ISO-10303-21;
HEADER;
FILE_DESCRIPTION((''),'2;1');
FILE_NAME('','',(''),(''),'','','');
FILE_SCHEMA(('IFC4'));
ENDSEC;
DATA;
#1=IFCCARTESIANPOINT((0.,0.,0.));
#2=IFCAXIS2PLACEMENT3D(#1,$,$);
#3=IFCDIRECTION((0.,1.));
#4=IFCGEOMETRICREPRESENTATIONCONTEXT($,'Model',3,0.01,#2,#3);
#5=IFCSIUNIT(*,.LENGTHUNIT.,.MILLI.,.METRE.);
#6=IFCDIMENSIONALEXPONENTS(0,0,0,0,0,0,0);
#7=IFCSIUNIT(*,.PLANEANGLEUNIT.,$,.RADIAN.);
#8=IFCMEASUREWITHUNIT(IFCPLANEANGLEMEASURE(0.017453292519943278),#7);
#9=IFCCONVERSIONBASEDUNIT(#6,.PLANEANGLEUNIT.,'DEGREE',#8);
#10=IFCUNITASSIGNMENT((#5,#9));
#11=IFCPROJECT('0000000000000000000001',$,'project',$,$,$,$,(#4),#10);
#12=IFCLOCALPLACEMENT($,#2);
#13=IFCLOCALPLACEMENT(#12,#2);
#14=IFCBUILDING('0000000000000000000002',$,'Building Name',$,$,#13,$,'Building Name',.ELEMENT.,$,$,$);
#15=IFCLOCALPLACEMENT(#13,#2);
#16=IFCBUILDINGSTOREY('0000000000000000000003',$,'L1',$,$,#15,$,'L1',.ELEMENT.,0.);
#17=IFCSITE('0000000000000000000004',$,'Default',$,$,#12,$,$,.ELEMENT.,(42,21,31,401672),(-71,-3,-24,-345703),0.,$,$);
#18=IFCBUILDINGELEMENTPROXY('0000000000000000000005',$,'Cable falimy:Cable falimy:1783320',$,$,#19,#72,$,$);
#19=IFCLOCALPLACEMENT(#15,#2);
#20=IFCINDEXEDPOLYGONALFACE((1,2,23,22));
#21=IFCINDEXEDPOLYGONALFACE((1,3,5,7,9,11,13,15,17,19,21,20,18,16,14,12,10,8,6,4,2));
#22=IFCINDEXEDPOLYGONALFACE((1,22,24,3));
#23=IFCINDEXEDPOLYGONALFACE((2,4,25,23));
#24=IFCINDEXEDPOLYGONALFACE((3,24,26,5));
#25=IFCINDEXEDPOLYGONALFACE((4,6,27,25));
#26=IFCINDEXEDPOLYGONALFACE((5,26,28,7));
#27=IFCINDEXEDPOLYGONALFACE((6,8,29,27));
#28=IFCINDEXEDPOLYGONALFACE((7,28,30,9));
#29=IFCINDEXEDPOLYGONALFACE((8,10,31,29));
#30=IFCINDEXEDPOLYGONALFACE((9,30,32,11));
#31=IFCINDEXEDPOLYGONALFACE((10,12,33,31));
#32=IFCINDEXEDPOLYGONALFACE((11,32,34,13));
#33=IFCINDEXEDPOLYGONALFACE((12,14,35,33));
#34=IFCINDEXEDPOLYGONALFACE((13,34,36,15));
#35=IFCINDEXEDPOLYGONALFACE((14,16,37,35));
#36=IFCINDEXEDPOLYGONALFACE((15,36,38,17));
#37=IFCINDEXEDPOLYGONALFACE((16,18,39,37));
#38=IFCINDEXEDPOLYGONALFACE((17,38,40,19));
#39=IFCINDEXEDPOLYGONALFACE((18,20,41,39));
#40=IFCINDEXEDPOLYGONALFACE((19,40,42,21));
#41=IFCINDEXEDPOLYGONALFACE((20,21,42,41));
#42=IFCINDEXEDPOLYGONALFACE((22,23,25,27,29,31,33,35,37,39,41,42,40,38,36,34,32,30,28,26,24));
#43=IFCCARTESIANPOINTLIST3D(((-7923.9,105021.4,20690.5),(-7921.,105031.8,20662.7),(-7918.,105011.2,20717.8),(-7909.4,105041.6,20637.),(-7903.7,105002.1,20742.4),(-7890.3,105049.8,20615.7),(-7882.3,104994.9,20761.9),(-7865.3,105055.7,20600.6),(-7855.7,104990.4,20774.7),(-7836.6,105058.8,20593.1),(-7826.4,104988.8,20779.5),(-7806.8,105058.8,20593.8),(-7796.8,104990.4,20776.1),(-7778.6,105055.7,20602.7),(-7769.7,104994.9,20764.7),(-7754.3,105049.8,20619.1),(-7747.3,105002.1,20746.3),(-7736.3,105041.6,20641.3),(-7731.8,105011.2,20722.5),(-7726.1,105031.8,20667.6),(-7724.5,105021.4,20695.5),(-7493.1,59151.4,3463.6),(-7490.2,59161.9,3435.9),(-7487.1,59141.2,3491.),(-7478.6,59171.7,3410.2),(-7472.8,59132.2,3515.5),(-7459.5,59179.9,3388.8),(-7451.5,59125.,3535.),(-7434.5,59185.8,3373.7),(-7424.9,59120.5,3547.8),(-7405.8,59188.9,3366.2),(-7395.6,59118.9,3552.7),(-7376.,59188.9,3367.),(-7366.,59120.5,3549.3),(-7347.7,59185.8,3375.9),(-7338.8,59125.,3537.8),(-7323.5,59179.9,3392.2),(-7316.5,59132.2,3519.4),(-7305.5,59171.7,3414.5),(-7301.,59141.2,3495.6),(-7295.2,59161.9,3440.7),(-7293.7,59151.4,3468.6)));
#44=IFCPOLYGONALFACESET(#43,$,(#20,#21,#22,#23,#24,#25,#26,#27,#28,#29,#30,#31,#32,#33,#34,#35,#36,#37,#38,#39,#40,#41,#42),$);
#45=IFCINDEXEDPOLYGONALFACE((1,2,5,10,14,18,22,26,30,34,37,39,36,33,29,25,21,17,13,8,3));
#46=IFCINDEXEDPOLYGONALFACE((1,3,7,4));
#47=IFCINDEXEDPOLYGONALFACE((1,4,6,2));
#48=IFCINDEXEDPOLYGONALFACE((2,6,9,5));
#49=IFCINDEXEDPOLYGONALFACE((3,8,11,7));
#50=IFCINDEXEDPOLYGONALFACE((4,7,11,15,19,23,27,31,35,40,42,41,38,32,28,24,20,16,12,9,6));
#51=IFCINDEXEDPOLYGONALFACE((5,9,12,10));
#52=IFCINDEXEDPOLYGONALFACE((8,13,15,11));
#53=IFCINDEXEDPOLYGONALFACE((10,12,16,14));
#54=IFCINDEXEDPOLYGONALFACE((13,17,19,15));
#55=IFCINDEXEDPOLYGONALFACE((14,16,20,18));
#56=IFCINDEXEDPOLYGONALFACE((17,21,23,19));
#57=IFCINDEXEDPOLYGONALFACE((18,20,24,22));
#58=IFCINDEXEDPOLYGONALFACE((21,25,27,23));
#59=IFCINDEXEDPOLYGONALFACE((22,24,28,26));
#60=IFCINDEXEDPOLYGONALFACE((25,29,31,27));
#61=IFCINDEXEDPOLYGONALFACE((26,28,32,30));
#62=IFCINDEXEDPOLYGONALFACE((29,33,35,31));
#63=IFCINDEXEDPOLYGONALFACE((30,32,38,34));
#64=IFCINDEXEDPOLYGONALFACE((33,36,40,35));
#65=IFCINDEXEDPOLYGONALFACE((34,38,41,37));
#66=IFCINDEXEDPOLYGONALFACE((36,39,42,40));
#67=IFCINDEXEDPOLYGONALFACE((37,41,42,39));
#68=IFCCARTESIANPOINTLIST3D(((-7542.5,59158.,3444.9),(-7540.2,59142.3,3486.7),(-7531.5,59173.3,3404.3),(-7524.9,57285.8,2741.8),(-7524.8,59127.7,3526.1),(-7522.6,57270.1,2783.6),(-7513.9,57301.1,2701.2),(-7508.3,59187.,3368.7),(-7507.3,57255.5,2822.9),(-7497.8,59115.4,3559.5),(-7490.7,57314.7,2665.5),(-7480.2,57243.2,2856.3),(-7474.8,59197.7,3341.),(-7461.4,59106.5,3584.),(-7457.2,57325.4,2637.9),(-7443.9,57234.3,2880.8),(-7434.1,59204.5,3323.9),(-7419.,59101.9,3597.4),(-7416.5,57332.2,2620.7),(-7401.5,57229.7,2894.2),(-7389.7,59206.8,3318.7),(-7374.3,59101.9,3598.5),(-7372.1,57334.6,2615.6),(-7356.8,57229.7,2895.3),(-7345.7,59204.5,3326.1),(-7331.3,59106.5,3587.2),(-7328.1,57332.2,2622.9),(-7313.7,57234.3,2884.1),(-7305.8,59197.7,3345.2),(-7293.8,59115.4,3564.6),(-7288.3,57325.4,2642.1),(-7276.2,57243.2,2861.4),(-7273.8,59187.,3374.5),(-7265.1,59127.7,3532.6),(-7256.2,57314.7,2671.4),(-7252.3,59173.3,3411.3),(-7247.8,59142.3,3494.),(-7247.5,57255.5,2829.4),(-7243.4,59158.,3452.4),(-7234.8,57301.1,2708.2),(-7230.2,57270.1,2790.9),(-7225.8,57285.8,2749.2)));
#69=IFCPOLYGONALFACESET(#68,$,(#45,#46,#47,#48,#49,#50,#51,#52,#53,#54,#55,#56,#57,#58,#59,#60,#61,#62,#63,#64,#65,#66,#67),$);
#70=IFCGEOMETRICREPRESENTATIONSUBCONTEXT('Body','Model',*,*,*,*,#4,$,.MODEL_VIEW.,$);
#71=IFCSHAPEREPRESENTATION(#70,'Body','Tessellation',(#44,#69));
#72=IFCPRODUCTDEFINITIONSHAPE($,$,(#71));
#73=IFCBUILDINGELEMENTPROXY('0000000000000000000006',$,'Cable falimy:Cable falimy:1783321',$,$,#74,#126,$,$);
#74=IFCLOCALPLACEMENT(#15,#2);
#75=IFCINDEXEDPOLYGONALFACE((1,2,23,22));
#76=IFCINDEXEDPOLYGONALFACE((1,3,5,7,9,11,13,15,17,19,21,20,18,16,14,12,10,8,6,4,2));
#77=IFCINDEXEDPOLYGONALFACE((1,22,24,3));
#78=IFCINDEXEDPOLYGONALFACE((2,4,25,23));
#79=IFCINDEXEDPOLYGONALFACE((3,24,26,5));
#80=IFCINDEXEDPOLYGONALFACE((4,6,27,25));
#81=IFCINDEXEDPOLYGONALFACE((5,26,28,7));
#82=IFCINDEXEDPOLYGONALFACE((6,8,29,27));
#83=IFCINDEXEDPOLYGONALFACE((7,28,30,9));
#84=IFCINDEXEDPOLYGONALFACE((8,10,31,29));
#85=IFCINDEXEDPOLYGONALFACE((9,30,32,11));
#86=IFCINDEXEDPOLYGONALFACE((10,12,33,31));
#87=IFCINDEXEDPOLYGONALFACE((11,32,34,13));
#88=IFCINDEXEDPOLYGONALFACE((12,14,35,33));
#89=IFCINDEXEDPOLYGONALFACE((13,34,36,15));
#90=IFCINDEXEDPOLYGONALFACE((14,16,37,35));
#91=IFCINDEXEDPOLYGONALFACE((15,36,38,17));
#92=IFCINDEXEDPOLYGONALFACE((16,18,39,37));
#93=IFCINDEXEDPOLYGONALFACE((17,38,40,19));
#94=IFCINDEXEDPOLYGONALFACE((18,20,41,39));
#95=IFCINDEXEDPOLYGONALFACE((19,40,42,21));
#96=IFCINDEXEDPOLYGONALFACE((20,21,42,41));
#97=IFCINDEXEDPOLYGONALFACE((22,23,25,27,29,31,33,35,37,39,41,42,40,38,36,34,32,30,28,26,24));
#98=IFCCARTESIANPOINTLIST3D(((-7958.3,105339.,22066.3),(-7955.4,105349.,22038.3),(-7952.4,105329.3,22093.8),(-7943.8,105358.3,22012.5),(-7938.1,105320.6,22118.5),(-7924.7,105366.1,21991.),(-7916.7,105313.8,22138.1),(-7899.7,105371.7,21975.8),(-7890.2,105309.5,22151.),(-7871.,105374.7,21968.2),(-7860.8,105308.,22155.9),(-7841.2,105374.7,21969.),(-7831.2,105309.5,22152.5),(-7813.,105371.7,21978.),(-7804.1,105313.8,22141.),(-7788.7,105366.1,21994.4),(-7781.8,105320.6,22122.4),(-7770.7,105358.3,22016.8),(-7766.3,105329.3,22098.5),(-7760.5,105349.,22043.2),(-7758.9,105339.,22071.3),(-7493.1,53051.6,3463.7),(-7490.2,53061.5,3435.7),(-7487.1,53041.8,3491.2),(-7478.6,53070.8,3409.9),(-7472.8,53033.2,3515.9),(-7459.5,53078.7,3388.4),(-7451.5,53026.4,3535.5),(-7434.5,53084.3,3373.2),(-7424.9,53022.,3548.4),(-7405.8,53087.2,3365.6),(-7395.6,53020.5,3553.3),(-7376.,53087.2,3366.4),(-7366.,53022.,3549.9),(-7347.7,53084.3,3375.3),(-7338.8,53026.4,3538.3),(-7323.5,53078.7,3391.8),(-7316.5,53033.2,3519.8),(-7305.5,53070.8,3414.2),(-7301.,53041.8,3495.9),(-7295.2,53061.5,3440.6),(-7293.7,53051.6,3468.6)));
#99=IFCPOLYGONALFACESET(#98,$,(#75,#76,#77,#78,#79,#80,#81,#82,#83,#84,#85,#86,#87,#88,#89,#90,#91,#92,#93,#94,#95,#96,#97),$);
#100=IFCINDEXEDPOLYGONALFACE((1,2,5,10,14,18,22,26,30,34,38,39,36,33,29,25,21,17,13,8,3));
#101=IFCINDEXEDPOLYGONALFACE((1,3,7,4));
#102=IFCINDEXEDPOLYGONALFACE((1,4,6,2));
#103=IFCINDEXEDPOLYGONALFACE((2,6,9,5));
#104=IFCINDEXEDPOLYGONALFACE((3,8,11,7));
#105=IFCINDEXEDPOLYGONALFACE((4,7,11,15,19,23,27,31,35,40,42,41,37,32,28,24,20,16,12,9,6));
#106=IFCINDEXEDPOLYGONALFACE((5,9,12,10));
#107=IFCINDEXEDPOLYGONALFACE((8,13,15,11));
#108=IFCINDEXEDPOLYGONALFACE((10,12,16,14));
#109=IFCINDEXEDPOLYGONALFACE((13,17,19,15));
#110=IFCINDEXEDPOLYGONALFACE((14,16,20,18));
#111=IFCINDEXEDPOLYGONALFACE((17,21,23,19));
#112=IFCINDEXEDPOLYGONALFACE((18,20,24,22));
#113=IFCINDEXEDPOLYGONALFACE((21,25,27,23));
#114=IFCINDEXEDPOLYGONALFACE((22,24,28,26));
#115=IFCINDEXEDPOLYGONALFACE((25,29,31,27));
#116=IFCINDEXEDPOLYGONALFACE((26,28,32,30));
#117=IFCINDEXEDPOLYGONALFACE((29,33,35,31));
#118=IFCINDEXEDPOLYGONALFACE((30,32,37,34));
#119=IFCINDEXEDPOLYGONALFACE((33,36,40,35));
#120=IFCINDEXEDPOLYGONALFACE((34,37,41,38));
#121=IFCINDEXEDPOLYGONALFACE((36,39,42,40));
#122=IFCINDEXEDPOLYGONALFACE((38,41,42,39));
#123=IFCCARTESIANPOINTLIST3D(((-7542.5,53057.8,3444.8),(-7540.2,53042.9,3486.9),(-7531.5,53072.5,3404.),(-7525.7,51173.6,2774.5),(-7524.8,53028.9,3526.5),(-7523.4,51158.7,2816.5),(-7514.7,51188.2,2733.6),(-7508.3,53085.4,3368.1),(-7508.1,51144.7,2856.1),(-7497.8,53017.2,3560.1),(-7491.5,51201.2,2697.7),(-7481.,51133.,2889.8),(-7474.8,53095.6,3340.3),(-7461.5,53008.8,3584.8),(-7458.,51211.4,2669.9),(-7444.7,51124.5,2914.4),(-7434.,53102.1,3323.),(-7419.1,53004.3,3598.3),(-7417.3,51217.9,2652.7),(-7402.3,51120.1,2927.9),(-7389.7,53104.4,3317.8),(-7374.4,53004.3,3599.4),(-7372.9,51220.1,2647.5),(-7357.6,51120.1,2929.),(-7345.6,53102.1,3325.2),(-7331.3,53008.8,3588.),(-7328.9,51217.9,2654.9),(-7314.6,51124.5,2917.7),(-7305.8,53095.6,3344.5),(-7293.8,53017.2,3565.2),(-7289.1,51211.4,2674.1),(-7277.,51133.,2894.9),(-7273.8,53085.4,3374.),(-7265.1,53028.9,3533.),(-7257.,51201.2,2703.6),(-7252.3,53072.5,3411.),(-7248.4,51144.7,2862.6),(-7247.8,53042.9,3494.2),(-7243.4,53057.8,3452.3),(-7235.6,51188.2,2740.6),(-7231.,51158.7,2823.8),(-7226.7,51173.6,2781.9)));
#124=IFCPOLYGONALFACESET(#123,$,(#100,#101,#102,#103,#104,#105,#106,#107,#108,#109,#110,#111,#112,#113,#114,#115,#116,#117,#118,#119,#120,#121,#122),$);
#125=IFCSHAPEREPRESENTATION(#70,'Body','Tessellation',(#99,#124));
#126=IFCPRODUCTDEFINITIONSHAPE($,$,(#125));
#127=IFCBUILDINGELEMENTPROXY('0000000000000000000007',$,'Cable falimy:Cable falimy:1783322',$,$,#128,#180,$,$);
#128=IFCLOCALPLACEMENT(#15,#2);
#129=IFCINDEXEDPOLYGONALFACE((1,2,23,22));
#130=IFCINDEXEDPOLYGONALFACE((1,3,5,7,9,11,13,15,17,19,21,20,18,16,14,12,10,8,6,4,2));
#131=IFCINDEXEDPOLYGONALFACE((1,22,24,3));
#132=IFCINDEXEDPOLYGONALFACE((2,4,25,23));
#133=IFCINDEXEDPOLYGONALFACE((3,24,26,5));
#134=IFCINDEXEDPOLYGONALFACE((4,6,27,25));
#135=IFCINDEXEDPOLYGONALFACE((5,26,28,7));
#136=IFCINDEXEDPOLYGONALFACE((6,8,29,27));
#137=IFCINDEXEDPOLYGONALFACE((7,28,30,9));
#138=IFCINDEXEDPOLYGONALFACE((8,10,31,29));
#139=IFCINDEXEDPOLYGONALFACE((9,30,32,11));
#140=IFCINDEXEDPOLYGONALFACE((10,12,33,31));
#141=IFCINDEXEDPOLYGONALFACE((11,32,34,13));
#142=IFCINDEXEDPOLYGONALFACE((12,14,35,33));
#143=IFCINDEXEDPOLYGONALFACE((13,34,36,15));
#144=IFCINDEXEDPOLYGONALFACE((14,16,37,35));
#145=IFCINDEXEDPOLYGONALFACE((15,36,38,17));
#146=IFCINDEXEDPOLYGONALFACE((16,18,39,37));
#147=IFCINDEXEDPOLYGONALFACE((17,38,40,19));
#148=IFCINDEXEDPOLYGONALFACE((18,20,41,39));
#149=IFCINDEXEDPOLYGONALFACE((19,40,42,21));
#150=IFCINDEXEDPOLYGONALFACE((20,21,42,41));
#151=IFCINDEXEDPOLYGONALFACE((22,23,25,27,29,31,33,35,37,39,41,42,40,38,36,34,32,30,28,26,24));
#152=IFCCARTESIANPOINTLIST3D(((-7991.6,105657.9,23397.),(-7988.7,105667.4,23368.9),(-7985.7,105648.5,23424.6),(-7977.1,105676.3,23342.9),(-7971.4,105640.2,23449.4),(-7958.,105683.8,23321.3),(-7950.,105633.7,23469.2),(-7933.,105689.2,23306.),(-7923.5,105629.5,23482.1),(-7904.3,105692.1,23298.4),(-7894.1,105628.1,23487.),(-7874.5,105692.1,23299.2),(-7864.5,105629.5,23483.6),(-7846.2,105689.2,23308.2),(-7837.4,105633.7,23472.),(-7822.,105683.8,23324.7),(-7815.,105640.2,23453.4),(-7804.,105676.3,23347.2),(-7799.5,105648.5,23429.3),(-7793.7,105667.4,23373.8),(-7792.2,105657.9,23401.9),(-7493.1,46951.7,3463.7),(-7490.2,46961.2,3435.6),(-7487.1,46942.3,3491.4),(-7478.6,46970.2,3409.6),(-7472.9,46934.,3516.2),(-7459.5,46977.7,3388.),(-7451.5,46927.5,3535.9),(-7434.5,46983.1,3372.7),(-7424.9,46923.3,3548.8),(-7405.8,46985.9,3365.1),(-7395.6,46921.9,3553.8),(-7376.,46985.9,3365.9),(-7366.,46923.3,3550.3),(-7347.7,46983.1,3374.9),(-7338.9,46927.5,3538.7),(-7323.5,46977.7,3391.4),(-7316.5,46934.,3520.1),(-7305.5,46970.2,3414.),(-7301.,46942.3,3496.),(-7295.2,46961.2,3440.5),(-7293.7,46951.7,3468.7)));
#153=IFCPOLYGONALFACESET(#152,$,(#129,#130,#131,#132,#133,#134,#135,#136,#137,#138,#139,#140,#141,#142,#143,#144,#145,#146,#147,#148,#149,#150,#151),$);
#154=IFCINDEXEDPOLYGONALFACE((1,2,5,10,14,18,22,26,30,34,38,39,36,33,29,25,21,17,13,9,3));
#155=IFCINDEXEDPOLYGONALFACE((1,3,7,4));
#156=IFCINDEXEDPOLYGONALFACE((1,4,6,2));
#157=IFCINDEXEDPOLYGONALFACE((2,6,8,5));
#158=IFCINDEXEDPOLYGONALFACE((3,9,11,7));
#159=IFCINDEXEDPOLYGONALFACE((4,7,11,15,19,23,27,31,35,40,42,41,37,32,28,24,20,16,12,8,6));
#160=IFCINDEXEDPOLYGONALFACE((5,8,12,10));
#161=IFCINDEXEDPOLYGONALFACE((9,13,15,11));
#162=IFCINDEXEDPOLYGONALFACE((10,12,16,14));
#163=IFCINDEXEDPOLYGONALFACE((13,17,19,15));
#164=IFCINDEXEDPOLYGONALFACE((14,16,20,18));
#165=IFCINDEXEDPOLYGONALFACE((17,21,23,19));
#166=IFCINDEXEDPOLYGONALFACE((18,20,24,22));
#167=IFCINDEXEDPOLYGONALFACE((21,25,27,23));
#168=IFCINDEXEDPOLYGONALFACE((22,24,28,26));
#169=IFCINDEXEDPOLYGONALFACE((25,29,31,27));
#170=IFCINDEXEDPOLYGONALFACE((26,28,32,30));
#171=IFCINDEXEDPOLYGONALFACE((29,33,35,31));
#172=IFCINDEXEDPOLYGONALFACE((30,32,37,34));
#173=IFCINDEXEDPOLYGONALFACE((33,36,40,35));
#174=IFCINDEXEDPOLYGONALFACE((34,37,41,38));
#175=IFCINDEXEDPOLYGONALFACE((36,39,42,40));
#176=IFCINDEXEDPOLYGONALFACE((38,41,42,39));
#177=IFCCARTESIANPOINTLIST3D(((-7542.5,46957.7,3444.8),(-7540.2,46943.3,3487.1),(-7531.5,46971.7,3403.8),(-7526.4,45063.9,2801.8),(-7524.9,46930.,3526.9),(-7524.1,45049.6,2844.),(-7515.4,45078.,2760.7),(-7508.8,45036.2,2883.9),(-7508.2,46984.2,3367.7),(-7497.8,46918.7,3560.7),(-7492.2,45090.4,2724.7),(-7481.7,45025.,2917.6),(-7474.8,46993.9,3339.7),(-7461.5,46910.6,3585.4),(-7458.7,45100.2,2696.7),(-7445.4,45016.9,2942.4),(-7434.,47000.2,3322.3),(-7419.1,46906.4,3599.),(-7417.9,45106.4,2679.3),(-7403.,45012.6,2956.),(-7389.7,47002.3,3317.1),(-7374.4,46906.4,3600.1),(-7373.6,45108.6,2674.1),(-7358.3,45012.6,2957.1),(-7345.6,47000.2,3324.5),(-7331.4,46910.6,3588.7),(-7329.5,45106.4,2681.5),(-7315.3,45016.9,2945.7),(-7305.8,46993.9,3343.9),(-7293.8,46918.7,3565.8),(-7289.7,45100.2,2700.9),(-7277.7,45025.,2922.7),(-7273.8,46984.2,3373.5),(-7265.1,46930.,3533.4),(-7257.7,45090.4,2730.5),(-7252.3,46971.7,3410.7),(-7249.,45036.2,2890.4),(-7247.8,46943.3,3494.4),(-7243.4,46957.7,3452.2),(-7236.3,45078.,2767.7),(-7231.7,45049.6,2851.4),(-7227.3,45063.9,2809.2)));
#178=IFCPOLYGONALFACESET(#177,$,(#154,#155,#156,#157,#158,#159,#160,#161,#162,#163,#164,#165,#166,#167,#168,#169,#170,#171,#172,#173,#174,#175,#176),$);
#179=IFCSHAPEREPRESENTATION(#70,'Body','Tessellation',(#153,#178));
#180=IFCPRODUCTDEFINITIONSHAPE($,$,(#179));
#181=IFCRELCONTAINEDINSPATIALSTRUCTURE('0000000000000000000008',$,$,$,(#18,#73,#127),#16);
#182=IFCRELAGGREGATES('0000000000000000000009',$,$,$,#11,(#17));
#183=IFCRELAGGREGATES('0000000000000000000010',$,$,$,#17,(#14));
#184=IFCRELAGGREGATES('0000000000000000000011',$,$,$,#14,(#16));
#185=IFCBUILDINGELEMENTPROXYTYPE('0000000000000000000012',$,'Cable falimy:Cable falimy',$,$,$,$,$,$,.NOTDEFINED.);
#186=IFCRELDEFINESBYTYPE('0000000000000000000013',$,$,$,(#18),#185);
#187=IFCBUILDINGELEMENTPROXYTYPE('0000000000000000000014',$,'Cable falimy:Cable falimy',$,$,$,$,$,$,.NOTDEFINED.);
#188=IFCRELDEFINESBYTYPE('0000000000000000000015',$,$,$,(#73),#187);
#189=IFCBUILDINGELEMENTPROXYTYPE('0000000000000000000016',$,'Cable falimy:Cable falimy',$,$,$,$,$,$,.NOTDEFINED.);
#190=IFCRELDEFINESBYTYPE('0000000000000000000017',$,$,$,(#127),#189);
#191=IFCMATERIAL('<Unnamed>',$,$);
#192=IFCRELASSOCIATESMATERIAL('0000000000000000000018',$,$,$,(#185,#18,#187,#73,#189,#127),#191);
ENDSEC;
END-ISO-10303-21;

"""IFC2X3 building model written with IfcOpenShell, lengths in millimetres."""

from ifc_helpers import new_model, entity, si_unit, converted_unit, direction, frame, frame_2d, origin, place, context, subcontext, project, spatial, circle, extrude, source, transform, mapped, material, type_object, type_shapes, element, save


model = new_model("IFC2X3")

# Units and contexts
model_context = context("Model", 3, precision=0.01, world=origin(), true_north=direction((0.0, 1.0)))
body_context = subcontext(model_context, "Body", "Model", "MODEL_VIEW")
ifc_project = project(units=[si_unit("LENGTHUNIT", "METRE", prefix="MILLI"), converted_unit("PLANEANGLEUNIT", "DEGREE", entity("IfcPlaneAngleMeasure", 0.017453292519943278), si_unit("PLANEANGLEUNIT", "RADIAN"), dimensions=[0, 0, 0, 0, 0, 0, 0])], contexts=[model_context])

# Site, building, storey
site_placement = place(None, origin())
site = spatial("IfcSite", under=ifc_project, at=site_placement, Name="Default", CompositionType="ELEMENT", RefLatitude=(42, 21, 31, 401672), RefLongitude=(-71, -3, -24, -345703), RefElevation=0.0)
building_placement = place(site_placement, origin())
building = spatial("IfcBuilding", under=site, at=building_placement, Name="Building Name", LongName="Building Name", CompositionType="ELEMENT")
storey_placement = place(building_placement, origin())
storey = spatial("IfcBuildingStorey", under=building, at=storey_placement, Name="L1", LongName="L1", CompositionType="ELEMENT", Elevation=0.0)

# Shared definitions
ifc_material = material(Name="<Unnamed>")

# Building element proxies
building_element_proxy_type_1 = type_object("IfcBuildingElementProxyType", Name="Cable falimy:Cable falimy", PredefinedType="NOTDEFINED", material=ifc_material)
shared_shape_1 = source(origin(), body_context, "Body", "SweptSolid", [
    extrude(circle(Radius=100.0, at=frame_2d((0.0, 0.0), x_axis=(1.0, 0.0))), frame((0.0, 0.0, 0.0), z_axis=(0.936121, 0.0, 0.351678), x_axis=(-0.351678, 0.0, 0.936121)), (0.0, 0.0, 1.0), 49000.0),
    extrude(circle(Radius=150.0, at=frame_2d((0.0, 0.0), x_axis=(1.0, 0.0))), frame((-1872.2, 0.0, -703.4), z_axis=(0.936121, 0.0, 0.351678), x_axis=(0.351678, 0.0, -0.936121)), (0.0, 0.0, 1.0), 2000.0),
])
type_shapes(building_element_proxy_type_1, [shared_shape_1])
proxy_1_placement = place(storey_placement, frame((-7393.2, 59154.1, 3459.1), z_axis=(-0.025001, 0.0, 0.999687), x_axis=(0.0, 1.0, 0.0)))
element("IfcBuildingElementProxy", 1, at=proxy_1_placement, inside=storey, type_object=building_element_proxy_type_1, material=ifc_material, Name="Cable falimy:Cable falimy:1783320", context=body_context, shape_type="MappedRepresentation", body=[
    mapped(shared_shape_1, transform((0.0, 0.0, 0.0), scale=1.0)),
])
building_element_proxy_type_2 = type_object("IfcBuildingElementProxyType", Name="Cable falimy:Cable falimy", PredefinedType="NOTDEFINED", material=ifc_material)
shared_shape_2 = source(origin(), body_context, "Body", "SweptSolid", [
    extrude(circle(Radius=100.0, at=frame_2d((0.0, 0.0), x_axis=(1.0, 0.0))), frame((0.0, 0.0, 0.0), z_axis=(0.942116, 0.0, 0.335287), x_axis=(-0.335287, 0.0, 0.942116)), (0.0, 0.0, 1.0), 55500.0),
    extrude(circle(Radius=150.0, at=frame_2d((0.0, 0.0), x_axis=(1.0, 0.0))), frame((-1884.2, 0.0, -670.6), z_axis=(0.942116, 0.0, 0.335287), x_axis=(0.335287, 0.0, -0.942116)), (0.0, 0.0, 1.0), 2000.0),
])
type_shapes(building_element_proxy_type_2, [shared_shape_2])
proxy_2_placement = place(storey_placement, frame((-7393.2, 53054.1, 3459.1), z_axis=(-0.025001, 0.0, 0.999687), x_axis=(0.0, 1.0, 0.0)))
element("IfcBuildingElementProxy", 2, at=proxy_2_placement, inside=storey, type_object=building_element_proxy_type_2, material=ifc_material, Name="Cable falimy:Cable falimy:1783321", context=body_context, shape_type="MappedRepresentation", body=[
    mapped(shared_shape_2, transform((0.0, 0.0, 0.0), scale=1.0)),
])
building_element_proxy_type_3 = type_object("IfcBuildingElementProxyType", Name="Cable falimy:Cable falimy", PredefinedType="NOTDEFINED", material=ifc_material)
shared_shape_3 = source(origin(), body_context, "Body", "SweptSolid", [
    extrude(circle(Radius=100.0, at=frame_2d((0.0, 0.0), x_axis=(1.0, 0.0))), frame((0.0, 0.0, 0.0), z_axis=(0.946874, 0.0, 0.321605), x_axis=(-0.321605, 0.0, 0.946874)), (0.0, 0.0, 1.0), 62000.0),
    extrude(circle(Radius=150.0, at=frame_2d((0.0, 0.0), x_axis=(1.0, 0.0))), frame((-1893.7, 0.0, -643.2), z_axis=(0.946874, 0.0, 0.321605), x_axis=(0.321605, 0.0, -0.946874)), (0.0, 0.0, 1.0), 2000.0),
])
type_shapes(building_element_proxy_type_3, [shared_shape_3])
proxy_3_placement = place(storey_placement, frame((-7393.2, 46954.1, 3459.1), z_axis=(-0.025001, 0.0, 0.999687), x_axis=(0.0, 1.0, 0.0)))
element("IfcBuildingElementProxy", 3, at=proxy_3_placement, inside=storey, type_object=building_element_proxy_type_3, material=ifc_material, Name="Cable falimy:Cable falimy:1783322", context=body_context, shape_type="MappedRepresentation", body=[
    mapped(shared_shape_3, transform((0.0, 0.0, 0.0), scale=1.0)),
])

save(model, "model.ifc")
